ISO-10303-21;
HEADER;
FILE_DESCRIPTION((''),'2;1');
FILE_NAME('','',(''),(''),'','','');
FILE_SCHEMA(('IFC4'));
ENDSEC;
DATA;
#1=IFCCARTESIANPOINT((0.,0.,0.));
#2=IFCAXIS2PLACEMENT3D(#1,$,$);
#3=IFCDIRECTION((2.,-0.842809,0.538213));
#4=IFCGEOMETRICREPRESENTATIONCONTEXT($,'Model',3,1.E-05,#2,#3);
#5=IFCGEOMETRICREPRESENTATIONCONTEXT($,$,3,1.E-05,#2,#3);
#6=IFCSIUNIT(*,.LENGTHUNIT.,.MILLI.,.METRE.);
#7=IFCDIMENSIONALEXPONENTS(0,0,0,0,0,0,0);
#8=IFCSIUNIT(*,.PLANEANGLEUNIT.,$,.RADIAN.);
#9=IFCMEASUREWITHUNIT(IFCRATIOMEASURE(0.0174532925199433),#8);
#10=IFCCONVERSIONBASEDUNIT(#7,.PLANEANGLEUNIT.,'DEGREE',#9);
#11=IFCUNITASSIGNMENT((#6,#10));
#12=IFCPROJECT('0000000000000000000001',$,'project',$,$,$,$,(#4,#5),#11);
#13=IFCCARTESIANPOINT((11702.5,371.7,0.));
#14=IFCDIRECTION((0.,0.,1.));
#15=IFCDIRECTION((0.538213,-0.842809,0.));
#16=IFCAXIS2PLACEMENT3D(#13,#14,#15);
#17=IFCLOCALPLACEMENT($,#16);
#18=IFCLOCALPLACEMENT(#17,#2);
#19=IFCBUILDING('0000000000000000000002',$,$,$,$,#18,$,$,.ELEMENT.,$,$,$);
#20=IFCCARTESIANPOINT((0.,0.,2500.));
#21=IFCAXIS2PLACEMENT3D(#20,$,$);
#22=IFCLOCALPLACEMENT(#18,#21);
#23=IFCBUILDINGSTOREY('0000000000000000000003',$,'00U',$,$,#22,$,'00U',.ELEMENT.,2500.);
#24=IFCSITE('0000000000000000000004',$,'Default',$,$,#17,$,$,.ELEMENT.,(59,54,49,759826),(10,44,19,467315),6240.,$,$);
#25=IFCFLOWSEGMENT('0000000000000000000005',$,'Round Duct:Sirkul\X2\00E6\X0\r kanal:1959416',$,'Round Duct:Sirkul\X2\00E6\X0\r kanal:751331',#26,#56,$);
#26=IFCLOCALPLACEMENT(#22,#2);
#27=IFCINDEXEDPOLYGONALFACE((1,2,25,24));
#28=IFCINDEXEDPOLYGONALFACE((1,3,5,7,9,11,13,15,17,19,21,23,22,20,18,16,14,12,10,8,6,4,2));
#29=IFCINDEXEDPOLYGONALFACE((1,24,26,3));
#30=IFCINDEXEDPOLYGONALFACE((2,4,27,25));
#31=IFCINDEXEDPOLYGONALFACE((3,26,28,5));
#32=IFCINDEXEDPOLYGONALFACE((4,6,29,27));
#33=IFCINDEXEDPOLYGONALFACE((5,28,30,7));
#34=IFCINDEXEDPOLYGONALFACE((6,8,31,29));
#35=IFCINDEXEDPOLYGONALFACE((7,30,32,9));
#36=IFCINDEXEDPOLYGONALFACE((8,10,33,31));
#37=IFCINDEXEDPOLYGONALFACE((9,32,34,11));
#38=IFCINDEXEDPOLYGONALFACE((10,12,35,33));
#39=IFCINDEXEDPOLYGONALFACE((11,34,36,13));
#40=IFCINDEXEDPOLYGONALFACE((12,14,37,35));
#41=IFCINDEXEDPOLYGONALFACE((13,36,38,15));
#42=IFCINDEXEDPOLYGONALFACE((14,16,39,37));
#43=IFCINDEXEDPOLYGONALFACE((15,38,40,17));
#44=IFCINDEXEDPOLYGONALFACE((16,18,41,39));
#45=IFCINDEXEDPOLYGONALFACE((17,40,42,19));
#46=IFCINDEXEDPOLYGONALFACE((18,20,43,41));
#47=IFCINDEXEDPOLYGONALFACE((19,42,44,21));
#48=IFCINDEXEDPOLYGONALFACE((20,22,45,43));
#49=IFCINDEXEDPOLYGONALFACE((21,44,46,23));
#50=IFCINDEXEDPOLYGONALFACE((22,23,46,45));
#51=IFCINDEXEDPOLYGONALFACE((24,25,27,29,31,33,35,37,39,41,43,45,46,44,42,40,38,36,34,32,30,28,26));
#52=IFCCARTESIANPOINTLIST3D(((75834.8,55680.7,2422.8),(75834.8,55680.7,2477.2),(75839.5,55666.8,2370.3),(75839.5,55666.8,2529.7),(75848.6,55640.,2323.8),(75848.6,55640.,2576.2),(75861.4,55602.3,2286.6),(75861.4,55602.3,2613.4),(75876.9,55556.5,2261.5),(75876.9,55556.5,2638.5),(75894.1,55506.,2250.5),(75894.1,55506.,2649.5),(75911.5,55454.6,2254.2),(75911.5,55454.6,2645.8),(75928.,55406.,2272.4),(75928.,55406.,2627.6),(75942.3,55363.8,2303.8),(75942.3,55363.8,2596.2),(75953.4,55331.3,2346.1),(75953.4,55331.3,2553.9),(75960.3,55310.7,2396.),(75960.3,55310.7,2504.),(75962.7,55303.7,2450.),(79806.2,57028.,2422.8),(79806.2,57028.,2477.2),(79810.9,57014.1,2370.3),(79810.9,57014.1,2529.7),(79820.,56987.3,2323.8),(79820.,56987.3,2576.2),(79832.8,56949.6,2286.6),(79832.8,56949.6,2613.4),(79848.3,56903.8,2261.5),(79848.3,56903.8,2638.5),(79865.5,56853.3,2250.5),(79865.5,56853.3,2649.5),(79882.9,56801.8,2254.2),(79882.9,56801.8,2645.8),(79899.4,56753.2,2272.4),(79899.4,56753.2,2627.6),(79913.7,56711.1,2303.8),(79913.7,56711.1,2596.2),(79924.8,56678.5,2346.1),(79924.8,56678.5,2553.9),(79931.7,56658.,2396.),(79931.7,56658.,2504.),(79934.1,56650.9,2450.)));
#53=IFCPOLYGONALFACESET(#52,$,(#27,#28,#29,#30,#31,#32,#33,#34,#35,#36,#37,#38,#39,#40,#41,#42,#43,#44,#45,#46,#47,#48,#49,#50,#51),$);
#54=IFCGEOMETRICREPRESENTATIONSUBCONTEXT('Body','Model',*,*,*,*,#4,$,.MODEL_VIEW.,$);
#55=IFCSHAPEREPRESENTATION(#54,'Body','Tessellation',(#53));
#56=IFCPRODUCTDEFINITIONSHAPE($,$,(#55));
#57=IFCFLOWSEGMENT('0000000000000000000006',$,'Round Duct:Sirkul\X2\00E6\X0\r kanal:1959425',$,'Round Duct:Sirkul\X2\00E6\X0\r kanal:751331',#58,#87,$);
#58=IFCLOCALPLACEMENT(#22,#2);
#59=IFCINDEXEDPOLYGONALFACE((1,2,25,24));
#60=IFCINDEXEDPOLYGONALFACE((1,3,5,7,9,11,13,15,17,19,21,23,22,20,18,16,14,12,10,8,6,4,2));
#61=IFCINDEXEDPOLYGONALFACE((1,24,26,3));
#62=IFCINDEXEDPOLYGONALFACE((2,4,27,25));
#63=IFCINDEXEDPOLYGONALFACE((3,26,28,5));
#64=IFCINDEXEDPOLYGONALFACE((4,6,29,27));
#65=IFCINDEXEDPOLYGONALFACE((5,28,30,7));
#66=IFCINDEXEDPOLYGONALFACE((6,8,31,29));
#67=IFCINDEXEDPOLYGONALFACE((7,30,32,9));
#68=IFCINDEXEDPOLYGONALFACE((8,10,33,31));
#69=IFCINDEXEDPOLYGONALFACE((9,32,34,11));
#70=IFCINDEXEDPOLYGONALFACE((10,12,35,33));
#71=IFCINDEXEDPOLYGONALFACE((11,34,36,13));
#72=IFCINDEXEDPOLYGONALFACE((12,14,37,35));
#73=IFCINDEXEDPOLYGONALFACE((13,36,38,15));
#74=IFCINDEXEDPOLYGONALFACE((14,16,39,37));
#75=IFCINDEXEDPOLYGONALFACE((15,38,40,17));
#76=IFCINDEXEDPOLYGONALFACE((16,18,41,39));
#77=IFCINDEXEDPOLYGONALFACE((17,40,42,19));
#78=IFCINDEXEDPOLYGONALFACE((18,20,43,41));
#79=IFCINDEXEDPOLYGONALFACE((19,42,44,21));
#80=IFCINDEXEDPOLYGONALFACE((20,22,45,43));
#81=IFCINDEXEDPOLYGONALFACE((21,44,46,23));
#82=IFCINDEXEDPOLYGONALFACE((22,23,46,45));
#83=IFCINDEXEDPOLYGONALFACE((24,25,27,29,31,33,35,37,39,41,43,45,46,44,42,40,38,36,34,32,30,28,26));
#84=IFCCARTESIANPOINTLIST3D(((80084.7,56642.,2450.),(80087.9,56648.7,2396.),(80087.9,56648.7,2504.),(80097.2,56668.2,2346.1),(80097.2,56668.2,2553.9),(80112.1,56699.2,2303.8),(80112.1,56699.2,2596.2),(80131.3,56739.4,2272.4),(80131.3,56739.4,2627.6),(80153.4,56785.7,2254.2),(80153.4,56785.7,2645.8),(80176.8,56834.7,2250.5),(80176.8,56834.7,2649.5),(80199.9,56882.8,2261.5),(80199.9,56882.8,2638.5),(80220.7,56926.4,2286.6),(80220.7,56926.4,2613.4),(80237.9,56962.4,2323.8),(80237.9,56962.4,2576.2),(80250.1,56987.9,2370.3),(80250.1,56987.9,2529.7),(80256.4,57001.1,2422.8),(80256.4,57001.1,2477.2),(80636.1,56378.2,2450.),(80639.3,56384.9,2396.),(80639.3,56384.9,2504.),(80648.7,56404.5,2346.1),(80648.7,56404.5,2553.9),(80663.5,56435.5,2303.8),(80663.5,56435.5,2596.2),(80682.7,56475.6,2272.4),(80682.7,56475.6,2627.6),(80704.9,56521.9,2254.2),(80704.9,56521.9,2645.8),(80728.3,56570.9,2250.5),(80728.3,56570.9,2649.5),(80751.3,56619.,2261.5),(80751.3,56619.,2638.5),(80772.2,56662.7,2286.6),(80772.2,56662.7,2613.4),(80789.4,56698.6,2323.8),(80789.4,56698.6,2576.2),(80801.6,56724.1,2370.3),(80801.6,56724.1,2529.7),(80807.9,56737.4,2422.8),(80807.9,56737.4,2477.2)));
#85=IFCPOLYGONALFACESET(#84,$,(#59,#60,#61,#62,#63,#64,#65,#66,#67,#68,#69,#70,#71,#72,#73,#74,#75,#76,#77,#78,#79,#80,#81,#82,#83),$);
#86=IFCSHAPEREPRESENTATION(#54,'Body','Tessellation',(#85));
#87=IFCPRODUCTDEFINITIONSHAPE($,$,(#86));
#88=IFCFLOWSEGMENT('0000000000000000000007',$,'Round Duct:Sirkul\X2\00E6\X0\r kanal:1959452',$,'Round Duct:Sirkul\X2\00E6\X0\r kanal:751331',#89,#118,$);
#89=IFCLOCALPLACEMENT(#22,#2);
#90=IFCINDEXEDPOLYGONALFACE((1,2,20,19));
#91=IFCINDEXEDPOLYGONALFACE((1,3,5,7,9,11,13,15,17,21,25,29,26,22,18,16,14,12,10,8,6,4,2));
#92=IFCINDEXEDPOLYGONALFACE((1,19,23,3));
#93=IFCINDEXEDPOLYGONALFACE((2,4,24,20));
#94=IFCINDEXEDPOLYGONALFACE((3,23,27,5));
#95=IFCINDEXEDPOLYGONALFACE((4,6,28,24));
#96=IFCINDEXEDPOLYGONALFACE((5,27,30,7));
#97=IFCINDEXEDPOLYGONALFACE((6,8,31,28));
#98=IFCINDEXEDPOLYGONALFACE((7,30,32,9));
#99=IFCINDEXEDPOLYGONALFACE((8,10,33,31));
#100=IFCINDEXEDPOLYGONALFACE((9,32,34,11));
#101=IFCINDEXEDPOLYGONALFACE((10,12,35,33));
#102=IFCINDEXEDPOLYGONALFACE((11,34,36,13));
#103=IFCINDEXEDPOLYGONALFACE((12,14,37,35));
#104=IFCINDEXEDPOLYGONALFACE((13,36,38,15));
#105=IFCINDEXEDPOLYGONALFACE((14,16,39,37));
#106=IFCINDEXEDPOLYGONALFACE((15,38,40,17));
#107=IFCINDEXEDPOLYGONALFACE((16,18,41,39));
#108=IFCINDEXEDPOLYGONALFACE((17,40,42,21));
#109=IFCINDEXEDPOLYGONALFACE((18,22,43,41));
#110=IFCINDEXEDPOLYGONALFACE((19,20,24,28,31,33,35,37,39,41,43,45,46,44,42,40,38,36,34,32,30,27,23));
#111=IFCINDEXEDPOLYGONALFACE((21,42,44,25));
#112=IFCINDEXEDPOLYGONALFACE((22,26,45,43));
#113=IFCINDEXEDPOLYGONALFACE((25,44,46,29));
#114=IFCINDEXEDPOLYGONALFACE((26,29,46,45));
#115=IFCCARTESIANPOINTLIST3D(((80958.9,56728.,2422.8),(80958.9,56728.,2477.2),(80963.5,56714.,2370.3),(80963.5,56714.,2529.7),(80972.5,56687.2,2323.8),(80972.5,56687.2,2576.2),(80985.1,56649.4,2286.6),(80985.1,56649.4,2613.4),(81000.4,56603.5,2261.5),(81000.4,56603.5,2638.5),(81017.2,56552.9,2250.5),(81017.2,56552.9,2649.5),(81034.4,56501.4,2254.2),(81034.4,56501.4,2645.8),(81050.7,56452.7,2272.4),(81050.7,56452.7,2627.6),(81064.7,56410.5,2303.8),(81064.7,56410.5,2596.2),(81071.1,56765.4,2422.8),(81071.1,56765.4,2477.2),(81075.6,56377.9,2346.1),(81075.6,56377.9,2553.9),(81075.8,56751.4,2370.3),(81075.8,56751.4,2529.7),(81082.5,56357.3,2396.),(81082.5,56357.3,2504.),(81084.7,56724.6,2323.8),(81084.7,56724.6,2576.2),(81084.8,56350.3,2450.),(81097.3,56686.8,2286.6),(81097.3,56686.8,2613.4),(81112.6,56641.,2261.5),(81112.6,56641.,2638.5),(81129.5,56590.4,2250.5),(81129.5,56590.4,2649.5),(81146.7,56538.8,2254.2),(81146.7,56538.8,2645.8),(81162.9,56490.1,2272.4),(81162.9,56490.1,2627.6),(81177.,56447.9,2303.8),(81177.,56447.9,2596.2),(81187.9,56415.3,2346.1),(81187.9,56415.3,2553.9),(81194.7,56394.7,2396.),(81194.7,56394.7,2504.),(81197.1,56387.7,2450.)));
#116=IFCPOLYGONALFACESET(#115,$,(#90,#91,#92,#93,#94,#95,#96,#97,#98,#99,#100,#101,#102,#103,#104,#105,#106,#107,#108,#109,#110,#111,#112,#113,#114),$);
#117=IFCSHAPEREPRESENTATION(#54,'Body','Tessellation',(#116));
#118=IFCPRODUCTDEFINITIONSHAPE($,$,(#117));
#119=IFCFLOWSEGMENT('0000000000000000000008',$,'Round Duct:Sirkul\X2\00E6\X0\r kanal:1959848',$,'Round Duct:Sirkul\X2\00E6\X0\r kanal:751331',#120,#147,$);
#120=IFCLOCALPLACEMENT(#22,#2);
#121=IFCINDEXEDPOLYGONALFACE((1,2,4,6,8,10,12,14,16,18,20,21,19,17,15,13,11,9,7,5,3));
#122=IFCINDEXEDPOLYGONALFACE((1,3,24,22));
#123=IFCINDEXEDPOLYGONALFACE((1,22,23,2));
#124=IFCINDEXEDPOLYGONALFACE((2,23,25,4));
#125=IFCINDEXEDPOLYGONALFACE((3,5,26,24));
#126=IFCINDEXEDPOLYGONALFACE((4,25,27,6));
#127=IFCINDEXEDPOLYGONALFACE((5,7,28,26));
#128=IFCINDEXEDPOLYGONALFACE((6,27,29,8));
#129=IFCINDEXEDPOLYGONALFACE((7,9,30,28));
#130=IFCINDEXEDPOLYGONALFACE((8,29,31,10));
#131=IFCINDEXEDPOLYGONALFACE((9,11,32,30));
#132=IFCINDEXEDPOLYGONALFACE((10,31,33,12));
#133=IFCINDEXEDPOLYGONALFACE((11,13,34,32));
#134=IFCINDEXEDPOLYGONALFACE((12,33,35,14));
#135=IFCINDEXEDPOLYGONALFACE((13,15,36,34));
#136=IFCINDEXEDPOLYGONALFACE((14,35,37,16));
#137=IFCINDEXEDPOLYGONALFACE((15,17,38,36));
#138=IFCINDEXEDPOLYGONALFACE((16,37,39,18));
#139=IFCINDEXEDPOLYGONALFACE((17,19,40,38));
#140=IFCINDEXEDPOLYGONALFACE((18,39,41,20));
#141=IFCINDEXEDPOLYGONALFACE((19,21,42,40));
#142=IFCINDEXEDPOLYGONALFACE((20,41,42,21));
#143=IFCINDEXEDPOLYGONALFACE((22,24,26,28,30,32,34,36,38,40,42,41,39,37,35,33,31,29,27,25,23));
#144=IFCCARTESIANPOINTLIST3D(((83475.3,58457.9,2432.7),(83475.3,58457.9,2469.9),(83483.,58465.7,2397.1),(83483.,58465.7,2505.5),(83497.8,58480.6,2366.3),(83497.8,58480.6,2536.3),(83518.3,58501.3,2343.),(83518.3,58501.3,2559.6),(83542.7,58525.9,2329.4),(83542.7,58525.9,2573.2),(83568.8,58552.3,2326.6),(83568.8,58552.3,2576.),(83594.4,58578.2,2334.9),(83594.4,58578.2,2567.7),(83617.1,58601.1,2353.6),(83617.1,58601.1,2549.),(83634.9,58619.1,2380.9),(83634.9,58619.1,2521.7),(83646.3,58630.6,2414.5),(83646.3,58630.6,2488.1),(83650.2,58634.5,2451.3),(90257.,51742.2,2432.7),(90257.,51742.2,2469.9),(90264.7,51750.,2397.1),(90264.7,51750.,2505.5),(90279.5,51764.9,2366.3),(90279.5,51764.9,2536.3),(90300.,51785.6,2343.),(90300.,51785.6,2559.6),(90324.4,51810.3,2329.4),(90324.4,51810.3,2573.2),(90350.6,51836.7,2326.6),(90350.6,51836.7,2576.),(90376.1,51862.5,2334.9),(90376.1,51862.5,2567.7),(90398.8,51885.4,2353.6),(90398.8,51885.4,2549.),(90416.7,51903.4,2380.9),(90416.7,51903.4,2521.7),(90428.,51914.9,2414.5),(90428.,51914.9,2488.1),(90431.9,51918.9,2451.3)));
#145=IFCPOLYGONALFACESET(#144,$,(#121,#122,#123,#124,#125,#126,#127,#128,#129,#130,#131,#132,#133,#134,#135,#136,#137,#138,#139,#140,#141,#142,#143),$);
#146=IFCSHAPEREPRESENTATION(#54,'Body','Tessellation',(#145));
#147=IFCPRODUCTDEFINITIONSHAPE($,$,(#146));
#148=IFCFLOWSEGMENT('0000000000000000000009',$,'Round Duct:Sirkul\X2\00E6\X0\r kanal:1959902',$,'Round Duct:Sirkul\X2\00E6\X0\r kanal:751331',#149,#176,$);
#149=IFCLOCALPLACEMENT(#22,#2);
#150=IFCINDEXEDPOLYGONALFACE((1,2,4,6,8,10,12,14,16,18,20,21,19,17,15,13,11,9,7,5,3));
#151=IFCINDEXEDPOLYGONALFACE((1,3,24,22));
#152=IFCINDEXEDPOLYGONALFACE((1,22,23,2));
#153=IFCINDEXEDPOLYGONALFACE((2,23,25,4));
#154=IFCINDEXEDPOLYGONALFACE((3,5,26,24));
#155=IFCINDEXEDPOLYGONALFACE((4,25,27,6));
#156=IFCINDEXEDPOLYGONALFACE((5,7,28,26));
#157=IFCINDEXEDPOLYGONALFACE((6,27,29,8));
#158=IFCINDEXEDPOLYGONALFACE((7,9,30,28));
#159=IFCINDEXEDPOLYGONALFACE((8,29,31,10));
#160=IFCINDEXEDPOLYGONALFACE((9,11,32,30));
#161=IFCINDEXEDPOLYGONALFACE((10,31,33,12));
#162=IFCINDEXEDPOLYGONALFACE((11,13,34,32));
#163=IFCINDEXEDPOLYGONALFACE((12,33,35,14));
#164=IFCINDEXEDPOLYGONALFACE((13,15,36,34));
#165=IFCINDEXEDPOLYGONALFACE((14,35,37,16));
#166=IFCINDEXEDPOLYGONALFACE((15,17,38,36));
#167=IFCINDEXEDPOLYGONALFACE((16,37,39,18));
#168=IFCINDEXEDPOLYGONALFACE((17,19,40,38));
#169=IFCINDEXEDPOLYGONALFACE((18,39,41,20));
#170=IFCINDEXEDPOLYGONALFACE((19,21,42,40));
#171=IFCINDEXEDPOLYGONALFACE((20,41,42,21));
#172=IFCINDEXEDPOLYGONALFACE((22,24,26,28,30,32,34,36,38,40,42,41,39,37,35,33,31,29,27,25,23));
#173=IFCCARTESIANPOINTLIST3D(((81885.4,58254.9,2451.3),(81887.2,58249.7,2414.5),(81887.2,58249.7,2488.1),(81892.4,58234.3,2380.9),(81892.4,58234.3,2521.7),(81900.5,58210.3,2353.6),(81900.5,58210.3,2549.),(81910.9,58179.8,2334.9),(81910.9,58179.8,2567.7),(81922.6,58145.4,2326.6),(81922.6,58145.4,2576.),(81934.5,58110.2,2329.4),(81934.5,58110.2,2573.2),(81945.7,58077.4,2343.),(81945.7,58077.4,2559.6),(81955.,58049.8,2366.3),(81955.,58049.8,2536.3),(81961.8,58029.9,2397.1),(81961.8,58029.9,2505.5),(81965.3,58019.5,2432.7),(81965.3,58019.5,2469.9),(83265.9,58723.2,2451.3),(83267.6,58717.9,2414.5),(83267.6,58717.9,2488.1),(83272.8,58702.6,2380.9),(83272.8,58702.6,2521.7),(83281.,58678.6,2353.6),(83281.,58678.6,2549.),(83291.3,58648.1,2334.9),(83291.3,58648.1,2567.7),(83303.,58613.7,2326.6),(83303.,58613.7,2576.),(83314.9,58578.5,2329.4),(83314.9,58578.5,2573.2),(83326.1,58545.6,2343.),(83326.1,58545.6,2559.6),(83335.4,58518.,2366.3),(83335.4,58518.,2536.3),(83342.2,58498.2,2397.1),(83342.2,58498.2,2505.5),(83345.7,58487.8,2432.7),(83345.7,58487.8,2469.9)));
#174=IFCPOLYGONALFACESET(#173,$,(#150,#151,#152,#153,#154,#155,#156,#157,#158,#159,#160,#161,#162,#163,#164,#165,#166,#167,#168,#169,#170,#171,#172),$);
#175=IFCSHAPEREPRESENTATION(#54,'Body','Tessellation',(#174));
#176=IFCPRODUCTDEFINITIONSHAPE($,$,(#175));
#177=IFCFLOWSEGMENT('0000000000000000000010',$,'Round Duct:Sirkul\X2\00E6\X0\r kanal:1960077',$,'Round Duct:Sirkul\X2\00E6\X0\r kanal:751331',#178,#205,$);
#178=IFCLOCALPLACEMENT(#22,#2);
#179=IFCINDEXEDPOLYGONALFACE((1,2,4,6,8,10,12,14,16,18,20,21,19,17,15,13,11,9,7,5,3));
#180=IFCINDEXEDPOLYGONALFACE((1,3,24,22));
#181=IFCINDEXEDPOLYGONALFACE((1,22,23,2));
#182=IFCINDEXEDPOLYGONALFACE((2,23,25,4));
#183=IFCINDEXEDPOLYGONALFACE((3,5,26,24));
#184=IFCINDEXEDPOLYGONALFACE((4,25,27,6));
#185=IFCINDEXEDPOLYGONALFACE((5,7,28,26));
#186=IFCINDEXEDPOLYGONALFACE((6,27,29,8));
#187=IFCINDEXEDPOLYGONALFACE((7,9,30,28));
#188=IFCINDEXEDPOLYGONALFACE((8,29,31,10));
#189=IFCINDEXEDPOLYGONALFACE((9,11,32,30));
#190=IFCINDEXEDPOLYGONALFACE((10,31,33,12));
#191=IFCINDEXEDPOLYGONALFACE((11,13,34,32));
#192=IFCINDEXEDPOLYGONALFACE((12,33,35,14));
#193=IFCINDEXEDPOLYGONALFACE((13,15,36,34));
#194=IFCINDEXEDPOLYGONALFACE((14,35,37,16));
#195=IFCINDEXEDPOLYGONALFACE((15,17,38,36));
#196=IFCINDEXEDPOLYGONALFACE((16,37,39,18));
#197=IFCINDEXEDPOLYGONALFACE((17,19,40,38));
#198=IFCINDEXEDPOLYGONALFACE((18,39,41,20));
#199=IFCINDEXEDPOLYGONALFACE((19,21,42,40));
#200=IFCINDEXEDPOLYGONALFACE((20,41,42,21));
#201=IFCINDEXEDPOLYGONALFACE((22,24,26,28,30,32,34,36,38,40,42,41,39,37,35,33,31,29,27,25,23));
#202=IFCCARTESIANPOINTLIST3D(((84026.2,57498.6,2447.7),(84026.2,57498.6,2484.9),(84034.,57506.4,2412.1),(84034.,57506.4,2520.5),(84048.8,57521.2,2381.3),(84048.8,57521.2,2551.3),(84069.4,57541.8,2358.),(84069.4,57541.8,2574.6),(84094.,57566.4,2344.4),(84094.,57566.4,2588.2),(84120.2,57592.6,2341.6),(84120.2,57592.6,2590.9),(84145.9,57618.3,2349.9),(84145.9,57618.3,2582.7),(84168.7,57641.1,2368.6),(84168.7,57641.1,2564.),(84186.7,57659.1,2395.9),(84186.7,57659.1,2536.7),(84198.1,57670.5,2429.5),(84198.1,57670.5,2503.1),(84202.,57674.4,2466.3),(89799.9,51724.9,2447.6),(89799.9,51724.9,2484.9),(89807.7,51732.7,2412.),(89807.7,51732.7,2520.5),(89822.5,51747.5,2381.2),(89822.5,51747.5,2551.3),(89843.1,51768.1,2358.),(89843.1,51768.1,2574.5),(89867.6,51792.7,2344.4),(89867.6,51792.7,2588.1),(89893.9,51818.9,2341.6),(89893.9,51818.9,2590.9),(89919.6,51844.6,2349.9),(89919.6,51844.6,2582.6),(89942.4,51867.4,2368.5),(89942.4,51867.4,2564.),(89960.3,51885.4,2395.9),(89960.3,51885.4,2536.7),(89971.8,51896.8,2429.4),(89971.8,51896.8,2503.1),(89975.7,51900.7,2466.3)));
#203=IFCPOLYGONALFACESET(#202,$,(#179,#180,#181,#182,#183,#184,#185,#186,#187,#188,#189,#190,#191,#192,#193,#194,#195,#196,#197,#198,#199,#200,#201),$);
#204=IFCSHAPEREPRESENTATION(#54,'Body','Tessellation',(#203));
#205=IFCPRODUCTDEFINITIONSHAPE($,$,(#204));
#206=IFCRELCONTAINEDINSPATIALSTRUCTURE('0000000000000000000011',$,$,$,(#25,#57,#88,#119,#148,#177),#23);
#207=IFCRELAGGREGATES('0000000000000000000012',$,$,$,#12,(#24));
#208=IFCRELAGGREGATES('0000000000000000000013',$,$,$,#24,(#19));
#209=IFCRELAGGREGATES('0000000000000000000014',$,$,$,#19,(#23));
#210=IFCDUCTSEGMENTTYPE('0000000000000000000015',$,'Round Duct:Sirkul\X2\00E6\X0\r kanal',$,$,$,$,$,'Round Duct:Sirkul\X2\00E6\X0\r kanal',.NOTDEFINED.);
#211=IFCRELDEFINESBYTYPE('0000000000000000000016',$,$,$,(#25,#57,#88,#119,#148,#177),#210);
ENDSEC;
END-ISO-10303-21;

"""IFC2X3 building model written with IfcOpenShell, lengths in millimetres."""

from ifc_helpers import new_model, entity, si_unit, converted_unit, direction, frame, origin, origin_2d_with_axis, place, context, subcontext, project, spatial, circle, extrude, type_object, element, save


model = new_model("IFC2X3")

# Units and contexts
model_context = context("Model", 3, precision=1e-05, world=origin(), true_north=direction((2.0, -0.842809, 0.538213)))
context_of_model = context(None, 3, precision=1e-05, world=origin(), true_north=direction((2.0, -0.842809, 0.538213)))
body_context = subcontext(model_context, "Body", "Model", "MODEL_VIEW")
ifc_project = project(units=[si_unit("LENGTHUNIT", "METRE", prefix="MILLI"), converted_unit("PLANEANGLEUNIT", "DEGREE", entity("IfcRatioMeasure", 0.0174532925199433), si_unit("PLANEANGLEUNIT", "RADIAN"), dimensions=[0, 0, 0, 0, 0, 0, 0])], contexts=[model_context, context_of_model])

# Site, building, storey
site_placement = place(None, frame((11702.5, 371.7, 0.0), z_axis=(0.0, 0.0, 1.0), x_axis=(0.538213, -0.842809, 0.0)))
site = spatial("IfcSite", under=ifc_project, at=site_placement, Name="Default", CompositionType="ELEMENT", RefLatitude=(59, 54, 49, 759826), RefLongitude=(10, 44, 19, 467315), RefElevation=6240.0)
building_placement = place(site_placement, origin())
building = spatial("IfcBuilding", under=site, at=building_placement, CompositionType="ELEMENT")
storey_placement = place(building_placement, frame((0.0, 0.0, 2500.0)))
storey = spatial("IfcBuildingStorey", under=building, at=storey_placement, Name="00U", LongName="00U", CompositionType="ELEMENT", Elevation=2500.0)

# Flow segments
duct_segment_type_1 = type_object("IfcDuctSegmentType", Name="Round Duct:Sirkulær kanal", ElementType="Round Duct:Sirkulær kanal", PredefinedType="NOTDEFINED")
flow_segment_1_placement = place(storey_placement, origin())
element("IfcFlowSegment", 1, at=flow_segment_1_placement, inside=storey, type_object=duct_segment_type_1, Name="Round Duct:Sirkulær kanal:1959416", ObjectType="Round Duct:Sirkulær kanal:751331", context=body_context, shape_type="SweptSolid", body=[
    extrude(circle(Radius=200.0, at=origin_2d_with_axis()), frame((75898.5, 55493.1, 2450.0), z_axis=(0.946993, 0.321254, 0.0), x_axis=(0.321254, -0.946993, 0.0)), (0.0, 0.0, 1.0), 4193.7),
])
flow_segment_2_placement = place(storey_placement, origin())
element("IfcFlowSegment", 2, at=flow_segment_2_placement, inside=storey, type_object=duct_segment_type_1, Name="Round Duct:Sirkulær kanal:1959425", ObjectType="Round Duct:Sirkulær kanal:751331", context=body_context, shape_type="SweptSolid", body=[
    extrude(circle(Radius=200.0, at=origin_2d_with_axis()), frame((80722.4, 56558.6, 2450.0), z_axis=(-0.902118, 0.431489, 0.0), x_axis=(-0.431489, -0.902118, 0.0)), (0.0, 0.0, 1.0), 611.3),
])
flow_segment_3_placement = place(storey_placement, origin())
element("IfcFlowSegment", 3, at=flow_segment_3_placement, inside=storey, type_object=duct_segment_type_1, Name="Round Duct:Sirkulær kanal:1959452", ObjectType="Round Duct:Sirkulær kanal:751331", context=body_context, shape_type="SweptSolid", body=[
    extrude(circle(Radius=200.0, at=origin_2d_with_axis()), frame((81021.6, 56540.0, 2450.0), z_axis=(0.948667, 0.316277, 0.0), x_axis=(0.316277, -0.948667, 0.0)), (0.0, 0.0, 1.0), 118.3),
])
flow_segment_4_placement = place(storey_placement, origin())
element("IfcFlowSegment", 4, at=flow_segment_4_placement, inside=storey, type_object=duct_segment_type_1, Name="Round Duct:Sirkulær kanal:1959848", ObjectType="Round Duct:Sirkulær kanal:751331", context=body_context, shape_type="SweptSolid", body=[
    extrude(circle(Radius=125.0, at=origin_2d_with_axis()), frame((83562.2, 58545.7, 2451.3), z_axis=(0.710561, -0.703635, 0.0), x_axis=(0.703635, 0.710561, 0.0)), (0.0, 0.0, 1.0), 9544.2),
])
flow_segment_5_placement = place(storey_placement, origin())
element("IfcFlowSegment", 5, at=flow_segment_5_placement, inside=storey, type_object=duct_segment_type_1, Name="Round Duct:Sirkulær kanal:1959902", ObjectType="Round Duct:Sirkulær kanal:751331", context=body_context, shape_type="SweptSolid", body=[
    extrude(circle(Radius=125.0, at=origin_2d_with_axis()), frame((81925.6, 58136.5, 2451.3), z_axis=(0.946996, 0.321246, 0.0), x_axis=(-0.321246, 0.946996, 0.0)), (0.0, 0.0, 1.0), 1457.7),
])
flow_segment_6_placement = place(storey_placement, origin())
element("IfcFlowSegment", 6, at=flow_segment_6_placement, inside=storey, type_object=duct_segment_type_1, Name="Round Duct:Sirkulær kanal:1960077", ObjectType="Round Duct:Sirkulær kanal:751331", context=body_context, shape_type="SweptSolid", body=[
    extrude(circle(Radius=125.0, at=origin_2d_with_axis()), frame((89887.3, 51812.3, 2466.3), z_axis=(-0.707107, 0.707107, 0.000004), x_axis=(0.707107, 0.707107, 0.0)), (0.0, 0.0, 1.0), 8165.2),
])

save(model, "model.ifc")
